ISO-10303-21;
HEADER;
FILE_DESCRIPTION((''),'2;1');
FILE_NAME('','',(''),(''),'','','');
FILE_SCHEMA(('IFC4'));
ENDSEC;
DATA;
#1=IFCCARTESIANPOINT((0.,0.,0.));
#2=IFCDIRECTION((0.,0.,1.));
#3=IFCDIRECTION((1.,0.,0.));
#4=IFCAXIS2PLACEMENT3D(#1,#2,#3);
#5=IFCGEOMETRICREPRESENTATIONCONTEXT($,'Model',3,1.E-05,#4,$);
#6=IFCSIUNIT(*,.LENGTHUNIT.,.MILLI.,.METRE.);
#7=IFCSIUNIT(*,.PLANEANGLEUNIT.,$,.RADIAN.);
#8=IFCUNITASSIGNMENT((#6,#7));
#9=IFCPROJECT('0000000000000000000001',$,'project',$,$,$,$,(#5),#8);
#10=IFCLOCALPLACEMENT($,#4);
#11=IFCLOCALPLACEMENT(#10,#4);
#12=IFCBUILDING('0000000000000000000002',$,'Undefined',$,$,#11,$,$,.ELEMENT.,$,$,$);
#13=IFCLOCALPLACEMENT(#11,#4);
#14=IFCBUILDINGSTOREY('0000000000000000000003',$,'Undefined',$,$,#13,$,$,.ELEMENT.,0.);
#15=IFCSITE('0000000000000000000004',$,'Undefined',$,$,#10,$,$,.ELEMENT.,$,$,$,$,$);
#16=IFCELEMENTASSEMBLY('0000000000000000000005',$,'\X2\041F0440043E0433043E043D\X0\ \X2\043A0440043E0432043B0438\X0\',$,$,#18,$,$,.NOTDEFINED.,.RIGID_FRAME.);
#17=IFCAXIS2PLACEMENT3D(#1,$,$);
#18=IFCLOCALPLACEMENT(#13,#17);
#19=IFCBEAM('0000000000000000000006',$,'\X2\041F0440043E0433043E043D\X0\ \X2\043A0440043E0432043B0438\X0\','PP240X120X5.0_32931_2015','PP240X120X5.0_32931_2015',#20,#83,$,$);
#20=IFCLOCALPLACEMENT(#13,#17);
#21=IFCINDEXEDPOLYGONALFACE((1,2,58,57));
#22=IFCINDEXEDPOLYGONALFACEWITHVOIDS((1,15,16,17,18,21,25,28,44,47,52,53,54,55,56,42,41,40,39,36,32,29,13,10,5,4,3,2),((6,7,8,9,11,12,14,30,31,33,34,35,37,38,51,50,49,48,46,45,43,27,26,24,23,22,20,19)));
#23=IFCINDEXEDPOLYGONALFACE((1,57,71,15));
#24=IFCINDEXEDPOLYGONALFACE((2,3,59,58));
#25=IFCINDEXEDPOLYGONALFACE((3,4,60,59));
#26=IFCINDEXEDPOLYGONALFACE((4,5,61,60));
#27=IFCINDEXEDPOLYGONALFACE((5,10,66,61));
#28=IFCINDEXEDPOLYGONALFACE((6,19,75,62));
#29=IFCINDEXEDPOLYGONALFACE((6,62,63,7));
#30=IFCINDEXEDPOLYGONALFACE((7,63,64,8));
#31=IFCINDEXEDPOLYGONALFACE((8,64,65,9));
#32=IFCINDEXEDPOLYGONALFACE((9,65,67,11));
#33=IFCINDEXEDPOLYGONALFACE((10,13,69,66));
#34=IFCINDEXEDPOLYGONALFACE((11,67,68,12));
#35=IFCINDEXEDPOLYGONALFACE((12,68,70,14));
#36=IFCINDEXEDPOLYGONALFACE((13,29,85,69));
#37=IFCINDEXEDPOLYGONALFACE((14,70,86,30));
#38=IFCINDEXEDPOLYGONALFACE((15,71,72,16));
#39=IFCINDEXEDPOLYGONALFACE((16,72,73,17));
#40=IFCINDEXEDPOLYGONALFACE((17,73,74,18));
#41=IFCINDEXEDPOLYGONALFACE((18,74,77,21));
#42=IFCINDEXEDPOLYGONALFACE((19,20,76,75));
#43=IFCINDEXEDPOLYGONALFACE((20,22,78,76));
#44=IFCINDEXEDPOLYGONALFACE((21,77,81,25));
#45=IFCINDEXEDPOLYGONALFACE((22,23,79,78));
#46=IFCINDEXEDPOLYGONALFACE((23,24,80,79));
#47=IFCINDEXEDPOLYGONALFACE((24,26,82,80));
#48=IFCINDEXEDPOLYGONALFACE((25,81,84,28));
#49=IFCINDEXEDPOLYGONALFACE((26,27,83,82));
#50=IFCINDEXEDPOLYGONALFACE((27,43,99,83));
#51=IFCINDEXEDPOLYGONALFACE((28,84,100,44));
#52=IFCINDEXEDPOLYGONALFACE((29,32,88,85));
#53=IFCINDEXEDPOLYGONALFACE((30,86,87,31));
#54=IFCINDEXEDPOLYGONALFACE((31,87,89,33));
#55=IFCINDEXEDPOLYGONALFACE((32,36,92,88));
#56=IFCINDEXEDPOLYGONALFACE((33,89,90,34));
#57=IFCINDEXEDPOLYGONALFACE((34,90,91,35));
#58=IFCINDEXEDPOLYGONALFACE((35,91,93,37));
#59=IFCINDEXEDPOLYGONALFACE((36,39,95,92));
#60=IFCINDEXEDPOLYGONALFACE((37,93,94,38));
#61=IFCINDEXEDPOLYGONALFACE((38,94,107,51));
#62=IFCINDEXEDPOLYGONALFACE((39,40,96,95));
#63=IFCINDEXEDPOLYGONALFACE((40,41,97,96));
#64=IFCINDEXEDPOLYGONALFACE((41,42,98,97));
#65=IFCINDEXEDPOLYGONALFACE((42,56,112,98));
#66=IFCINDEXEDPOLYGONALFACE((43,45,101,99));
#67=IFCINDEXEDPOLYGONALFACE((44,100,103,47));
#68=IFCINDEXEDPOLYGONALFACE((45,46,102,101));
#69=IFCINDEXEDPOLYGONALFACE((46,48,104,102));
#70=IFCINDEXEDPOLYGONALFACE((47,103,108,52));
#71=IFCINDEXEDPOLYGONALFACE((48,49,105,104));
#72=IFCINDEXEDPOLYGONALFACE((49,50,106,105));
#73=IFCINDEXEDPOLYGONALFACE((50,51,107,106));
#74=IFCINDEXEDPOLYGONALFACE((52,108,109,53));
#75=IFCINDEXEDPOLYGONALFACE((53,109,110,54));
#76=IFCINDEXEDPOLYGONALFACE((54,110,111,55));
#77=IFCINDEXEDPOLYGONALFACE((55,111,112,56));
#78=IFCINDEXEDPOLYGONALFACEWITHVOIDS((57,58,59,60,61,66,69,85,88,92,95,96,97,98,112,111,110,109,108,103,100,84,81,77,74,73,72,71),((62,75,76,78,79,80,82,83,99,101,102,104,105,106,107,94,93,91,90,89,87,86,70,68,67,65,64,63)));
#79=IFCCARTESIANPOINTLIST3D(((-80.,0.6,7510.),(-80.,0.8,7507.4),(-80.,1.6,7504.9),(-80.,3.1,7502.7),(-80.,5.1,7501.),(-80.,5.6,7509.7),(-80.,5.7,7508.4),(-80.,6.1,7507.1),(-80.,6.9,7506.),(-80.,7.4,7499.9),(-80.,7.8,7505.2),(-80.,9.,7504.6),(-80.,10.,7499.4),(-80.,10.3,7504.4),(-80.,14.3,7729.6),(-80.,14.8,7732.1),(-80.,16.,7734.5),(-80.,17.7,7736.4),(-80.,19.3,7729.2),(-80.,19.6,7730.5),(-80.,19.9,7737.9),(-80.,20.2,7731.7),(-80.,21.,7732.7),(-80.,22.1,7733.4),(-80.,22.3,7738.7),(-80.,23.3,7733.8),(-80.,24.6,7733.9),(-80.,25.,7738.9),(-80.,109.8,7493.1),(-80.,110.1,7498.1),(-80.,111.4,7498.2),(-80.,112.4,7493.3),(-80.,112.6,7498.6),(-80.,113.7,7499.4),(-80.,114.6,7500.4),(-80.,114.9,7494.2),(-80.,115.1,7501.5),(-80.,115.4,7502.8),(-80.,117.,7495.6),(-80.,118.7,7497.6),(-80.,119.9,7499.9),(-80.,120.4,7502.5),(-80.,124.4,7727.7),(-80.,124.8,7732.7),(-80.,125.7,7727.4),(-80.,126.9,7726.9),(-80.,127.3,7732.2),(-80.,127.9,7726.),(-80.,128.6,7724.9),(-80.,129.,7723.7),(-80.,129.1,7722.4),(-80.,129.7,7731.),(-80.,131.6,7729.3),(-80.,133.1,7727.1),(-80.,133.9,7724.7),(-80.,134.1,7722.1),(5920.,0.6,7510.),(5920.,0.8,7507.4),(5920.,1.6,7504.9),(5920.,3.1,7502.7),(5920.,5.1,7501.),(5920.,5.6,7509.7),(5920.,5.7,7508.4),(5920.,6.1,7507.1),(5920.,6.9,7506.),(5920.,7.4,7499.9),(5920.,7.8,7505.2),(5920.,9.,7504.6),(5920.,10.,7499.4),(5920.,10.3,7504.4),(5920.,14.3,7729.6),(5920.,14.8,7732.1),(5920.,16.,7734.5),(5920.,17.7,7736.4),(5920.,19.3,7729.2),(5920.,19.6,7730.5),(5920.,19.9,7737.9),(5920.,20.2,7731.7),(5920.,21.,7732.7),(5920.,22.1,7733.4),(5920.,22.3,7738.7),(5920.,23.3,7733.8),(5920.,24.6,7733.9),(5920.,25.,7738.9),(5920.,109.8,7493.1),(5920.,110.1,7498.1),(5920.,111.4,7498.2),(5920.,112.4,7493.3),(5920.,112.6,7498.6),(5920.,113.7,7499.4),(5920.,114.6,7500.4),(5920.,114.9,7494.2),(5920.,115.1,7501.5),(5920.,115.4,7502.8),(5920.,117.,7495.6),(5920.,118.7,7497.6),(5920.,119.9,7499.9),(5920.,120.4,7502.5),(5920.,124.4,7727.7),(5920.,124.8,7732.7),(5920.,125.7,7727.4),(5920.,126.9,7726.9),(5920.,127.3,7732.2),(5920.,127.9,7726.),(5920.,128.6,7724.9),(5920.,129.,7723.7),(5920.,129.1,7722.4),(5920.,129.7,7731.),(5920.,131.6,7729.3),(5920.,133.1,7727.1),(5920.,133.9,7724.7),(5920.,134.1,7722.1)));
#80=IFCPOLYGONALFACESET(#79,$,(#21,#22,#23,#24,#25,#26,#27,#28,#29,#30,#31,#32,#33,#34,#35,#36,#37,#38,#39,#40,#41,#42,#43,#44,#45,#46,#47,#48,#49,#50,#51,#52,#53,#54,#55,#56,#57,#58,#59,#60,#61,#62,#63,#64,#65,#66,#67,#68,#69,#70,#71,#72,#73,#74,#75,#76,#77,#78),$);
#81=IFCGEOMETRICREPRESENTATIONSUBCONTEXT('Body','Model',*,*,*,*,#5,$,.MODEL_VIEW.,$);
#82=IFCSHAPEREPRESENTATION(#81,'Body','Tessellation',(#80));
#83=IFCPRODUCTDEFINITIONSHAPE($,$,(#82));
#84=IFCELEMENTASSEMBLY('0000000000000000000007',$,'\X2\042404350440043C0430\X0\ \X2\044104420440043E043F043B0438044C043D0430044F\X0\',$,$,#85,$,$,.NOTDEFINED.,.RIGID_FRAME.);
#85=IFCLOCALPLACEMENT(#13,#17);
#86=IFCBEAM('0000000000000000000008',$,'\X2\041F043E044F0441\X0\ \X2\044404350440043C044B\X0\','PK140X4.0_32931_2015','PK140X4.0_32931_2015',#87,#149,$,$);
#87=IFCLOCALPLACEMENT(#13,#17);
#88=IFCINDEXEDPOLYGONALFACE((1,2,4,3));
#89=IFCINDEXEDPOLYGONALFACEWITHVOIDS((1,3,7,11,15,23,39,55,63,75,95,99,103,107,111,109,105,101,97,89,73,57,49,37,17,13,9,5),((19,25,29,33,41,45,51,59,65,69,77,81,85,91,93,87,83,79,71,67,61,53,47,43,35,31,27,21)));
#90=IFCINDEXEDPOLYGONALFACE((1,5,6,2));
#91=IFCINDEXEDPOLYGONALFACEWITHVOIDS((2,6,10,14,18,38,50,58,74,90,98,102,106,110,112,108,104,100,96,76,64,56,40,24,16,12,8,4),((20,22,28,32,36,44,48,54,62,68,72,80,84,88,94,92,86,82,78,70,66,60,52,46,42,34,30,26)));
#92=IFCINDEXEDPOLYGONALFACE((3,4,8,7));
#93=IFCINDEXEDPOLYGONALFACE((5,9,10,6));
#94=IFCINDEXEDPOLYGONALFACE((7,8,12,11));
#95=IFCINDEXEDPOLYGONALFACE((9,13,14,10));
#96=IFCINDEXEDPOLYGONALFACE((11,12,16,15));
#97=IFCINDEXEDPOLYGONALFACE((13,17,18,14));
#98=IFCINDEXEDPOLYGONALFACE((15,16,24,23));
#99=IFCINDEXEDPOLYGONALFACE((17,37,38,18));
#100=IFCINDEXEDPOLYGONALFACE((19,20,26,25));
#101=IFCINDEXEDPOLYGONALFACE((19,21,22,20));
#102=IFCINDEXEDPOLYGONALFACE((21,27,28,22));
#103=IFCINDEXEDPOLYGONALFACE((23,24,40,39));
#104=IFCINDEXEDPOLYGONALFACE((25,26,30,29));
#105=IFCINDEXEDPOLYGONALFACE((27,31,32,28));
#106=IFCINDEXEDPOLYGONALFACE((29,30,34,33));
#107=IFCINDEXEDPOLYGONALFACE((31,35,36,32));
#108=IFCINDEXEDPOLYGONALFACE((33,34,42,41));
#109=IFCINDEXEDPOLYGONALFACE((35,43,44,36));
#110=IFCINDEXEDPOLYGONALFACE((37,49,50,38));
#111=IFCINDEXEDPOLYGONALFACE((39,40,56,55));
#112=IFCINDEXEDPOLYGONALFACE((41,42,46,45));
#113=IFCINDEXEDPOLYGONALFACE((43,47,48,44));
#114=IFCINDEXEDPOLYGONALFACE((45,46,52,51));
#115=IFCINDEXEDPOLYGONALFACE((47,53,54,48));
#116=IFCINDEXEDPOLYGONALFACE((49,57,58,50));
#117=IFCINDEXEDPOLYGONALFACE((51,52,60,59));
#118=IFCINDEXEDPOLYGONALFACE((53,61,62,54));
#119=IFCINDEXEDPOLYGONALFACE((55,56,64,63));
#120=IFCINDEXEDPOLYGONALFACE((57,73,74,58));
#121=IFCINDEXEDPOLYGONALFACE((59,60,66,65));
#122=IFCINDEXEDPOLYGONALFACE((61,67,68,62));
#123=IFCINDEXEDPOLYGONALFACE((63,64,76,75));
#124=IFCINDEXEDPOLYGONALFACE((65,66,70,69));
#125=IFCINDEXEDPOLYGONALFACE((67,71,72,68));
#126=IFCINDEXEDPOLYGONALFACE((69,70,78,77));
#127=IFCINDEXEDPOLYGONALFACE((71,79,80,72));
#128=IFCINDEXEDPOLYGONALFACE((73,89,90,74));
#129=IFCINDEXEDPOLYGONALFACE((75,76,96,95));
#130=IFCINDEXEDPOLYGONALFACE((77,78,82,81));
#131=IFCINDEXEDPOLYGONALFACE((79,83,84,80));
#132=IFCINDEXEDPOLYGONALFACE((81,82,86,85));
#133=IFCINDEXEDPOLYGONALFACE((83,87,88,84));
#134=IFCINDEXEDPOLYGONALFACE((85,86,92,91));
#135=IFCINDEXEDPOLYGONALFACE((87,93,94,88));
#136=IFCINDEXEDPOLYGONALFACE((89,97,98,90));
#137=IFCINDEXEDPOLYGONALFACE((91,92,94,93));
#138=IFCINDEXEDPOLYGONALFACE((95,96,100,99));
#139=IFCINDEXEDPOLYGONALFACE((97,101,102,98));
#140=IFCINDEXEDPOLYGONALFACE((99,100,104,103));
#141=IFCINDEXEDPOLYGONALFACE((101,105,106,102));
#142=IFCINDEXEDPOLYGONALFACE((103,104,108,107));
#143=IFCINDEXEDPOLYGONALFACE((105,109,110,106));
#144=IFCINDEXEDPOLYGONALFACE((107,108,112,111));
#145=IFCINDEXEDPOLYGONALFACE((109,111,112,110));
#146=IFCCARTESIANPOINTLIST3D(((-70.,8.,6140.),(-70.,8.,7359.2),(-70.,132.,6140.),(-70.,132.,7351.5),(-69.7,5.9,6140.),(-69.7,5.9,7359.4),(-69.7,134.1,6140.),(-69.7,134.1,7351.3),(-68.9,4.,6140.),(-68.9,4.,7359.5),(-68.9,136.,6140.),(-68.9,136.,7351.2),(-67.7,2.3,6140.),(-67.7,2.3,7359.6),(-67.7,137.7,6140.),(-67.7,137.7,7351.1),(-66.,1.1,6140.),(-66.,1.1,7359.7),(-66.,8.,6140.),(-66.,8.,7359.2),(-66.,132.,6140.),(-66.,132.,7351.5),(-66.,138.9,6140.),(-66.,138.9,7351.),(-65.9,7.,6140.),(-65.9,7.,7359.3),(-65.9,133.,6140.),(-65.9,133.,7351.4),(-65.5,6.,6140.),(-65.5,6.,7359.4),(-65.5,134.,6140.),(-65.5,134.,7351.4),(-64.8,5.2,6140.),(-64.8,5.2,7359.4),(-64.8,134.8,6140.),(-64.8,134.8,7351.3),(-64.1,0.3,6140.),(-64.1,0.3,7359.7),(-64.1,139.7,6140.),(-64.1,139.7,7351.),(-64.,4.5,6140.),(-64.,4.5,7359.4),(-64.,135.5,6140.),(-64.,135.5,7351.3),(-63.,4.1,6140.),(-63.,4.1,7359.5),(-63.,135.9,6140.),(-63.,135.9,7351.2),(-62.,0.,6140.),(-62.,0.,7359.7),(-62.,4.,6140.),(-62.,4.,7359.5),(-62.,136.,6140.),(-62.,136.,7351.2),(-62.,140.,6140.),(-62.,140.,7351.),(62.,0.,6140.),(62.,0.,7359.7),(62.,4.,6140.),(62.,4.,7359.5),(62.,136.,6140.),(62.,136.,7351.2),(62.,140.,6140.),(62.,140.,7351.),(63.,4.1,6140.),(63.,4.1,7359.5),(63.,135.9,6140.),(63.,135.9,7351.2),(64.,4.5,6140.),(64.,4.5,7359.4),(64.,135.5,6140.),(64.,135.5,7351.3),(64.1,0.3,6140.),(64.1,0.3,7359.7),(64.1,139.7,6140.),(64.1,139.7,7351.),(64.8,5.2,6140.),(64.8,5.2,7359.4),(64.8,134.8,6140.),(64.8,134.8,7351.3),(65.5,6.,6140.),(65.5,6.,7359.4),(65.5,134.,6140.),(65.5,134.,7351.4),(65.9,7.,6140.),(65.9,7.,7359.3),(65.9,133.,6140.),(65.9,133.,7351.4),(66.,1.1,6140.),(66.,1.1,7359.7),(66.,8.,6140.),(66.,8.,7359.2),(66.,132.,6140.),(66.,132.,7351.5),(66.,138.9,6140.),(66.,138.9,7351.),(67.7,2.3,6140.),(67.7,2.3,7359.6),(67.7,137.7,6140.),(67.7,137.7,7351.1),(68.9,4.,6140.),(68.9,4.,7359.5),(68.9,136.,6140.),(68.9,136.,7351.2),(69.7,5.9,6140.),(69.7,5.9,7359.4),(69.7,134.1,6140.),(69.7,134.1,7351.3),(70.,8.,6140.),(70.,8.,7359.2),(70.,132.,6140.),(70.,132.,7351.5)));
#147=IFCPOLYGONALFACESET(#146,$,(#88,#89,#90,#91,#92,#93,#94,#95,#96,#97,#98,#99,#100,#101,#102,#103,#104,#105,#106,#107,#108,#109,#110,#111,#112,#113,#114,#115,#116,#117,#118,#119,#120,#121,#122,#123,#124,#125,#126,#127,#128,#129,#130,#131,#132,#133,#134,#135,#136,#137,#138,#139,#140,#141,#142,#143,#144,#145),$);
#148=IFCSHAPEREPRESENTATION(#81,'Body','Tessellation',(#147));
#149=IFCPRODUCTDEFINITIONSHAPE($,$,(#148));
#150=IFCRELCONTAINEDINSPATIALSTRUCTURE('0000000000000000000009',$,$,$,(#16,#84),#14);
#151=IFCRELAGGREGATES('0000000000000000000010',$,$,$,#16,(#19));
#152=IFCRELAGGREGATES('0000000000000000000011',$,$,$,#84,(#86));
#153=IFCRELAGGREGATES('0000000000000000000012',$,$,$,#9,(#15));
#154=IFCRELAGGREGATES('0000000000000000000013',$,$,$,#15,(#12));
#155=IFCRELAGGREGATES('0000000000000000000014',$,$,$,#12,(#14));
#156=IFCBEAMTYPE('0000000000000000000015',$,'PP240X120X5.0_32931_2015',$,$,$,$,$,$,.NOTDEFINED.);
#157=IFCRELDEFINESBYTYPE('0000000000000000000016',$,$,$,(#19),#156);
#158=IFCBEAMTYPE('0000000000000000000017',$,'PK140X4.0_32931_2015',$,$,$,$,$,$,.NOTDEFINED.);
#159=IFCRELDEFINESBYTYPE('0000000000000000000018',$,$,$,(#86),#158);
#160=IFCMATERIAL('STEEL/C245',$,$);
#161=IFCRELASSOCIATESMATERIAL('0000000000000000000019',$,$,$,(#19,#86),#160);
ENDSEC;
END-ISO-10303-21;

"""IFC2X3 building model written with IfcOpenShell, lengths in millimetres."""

from ifc_helpers import new_model, si_unit, frame, origin_with_axes, origin_2d_with_axis, place, context, subcontext, project, spatial, hollow_rectangle, extrude, clip, halfspace, material, type_object, element, aggregate, save


model = new_model("IFC2X3")

# Units and contexts
model_context = context("Model", 3, precision=1e-05, world=origin_with_axes())
body_context = subcontext(model_context, "Body", "Model", "MODEL_VIEW")
ifc_project = project(units=[si_unit("LENGTHUNIT", "METRE", prefix="MILLI"), si_unit("PLANEANGLEUNIT", "RADIAN")], contexts=[model_context])

# Site, building, storey
site_placement = place(None, origin_with_axes())
site = spatial("IfcSite", under=ifc_project, at=site_placement, Name="Undefined", CompositionType="ELEMENT")
building_placement = place(site_placement, origin_with_axes())
building = spatial("IfcBuilding", under=site, at=building_placement, Name="Undefined", CompositionType="ELEMENT")
storey_placement = place(building_placement, origin_with_axes())
storey = spatial("IfcBuildingStorey", under=building, at=storey_placement, Name="Undefined", CompositionType="ELEMENT", Elevation=0.0)

# Shared definitions
ifc_material = material(Name="STEEL/C245")

# Element assembly, beam
beam_type_1 = type_object("IfcBeamType", Name="PP240X120X5.0_32931_2015", PredefinedType="NOTDEFINED")
assembly_1_placement = place(storey_placement, origin_with_axes())
assembly_1 = element("IfcElementAssembly", 1, at=assembly_1_placement, inside=storey, Name="Прогон кровли", AssemblyPlace="NOTDEFINED", PredefinedType="RIGID_FRAME")
beam_1_placement = place(assembly_1_placement, frame((5920.0, 67.4, 7616.0), z_axis=(0.0, 0.062378, 0.998053), x_axis=(-1.0, 0.0, 0.0)))
beam_1 = element("IfcBeam", 2, at=beam_1_placement, type_object=beam_type_1, material=ifc_material, Name="Прогон кровли", Description="PP240X120X5.0_32931_2015", ObjectType="PP240X120X5.0_32931_2015", context=body_context, shape_type="SweptSolid", body=[
    extrude(hollow_rectangle(XDim=120.0, YDim=240.0, WallThickness=5.0, InnerFilletRadius=5.0, OuterFilletRadius=10.0, at=origin_2d_with_axis()), frame((6000.0, 0.0, 0.0), z_axis=(-1.0, 0.0, 0.0), x_axis=(0.0, -1.0, 0.0)), (0.0, 0.0, 1.0), 6000.0),
])
aggregate(assembly_1, [beam_1])

# Element assembly, beam
assembly_2_placement = place(storey_placement, origin_with_axes())
assembly_2 = element("IfcElementAssembly", 3, at=assembly_2_placement, inside=storey, Name="Ферма строплиьная", AssemblyPlace="NOTDEFINED", PredefinedType="RIGID_FRAME")
beam_type_2 = type_object("IfcBeamType", Name="PK140X4.0_32931_2015", PredefinedType="NOTDEFINED")
beam_2_placement = place(assembly_2_placement, frame((0.0, 70.0, 7359.7), z_axis=(1.0, 0.0, 0.0), x_axis=(0.0, 0.0, -1.0)))
beam_2 = element("IfcBeam", 4, at=beam_2_placement, type_object=beam_type_2, material=ifc_material, Name="Пояс фермы", Description="PK140X4.0_32931_2015", ObjectType="PK140X4.0_32931_2015", context=body_context, shape_type="Clipping", body=[
    clip(extrude(hollow_rectangle(XDim=140.0, YDim=140.0, WallThickness=4.0, InnerFilletRadius=4.0, OuterFilletRadius=8.0, at=origin_2d_with_axis()), frame((1219.7, 0.0, 0.0), z_axis=(-1.0, 0.0, 0.0), x_axis=(0.0, -1.0, 0.0)), (0.0, 0.0, 1.0), 1219.8), halfspace(frame((10.5, 98.4, 0.0), z_axis=(0.998053, -0.062378, 0.0), x_axis=(0.0, 0.0, 1.0)), True)),
])
aggregate(assembly_2, [beam_2])

save(model, "model.ifc")
